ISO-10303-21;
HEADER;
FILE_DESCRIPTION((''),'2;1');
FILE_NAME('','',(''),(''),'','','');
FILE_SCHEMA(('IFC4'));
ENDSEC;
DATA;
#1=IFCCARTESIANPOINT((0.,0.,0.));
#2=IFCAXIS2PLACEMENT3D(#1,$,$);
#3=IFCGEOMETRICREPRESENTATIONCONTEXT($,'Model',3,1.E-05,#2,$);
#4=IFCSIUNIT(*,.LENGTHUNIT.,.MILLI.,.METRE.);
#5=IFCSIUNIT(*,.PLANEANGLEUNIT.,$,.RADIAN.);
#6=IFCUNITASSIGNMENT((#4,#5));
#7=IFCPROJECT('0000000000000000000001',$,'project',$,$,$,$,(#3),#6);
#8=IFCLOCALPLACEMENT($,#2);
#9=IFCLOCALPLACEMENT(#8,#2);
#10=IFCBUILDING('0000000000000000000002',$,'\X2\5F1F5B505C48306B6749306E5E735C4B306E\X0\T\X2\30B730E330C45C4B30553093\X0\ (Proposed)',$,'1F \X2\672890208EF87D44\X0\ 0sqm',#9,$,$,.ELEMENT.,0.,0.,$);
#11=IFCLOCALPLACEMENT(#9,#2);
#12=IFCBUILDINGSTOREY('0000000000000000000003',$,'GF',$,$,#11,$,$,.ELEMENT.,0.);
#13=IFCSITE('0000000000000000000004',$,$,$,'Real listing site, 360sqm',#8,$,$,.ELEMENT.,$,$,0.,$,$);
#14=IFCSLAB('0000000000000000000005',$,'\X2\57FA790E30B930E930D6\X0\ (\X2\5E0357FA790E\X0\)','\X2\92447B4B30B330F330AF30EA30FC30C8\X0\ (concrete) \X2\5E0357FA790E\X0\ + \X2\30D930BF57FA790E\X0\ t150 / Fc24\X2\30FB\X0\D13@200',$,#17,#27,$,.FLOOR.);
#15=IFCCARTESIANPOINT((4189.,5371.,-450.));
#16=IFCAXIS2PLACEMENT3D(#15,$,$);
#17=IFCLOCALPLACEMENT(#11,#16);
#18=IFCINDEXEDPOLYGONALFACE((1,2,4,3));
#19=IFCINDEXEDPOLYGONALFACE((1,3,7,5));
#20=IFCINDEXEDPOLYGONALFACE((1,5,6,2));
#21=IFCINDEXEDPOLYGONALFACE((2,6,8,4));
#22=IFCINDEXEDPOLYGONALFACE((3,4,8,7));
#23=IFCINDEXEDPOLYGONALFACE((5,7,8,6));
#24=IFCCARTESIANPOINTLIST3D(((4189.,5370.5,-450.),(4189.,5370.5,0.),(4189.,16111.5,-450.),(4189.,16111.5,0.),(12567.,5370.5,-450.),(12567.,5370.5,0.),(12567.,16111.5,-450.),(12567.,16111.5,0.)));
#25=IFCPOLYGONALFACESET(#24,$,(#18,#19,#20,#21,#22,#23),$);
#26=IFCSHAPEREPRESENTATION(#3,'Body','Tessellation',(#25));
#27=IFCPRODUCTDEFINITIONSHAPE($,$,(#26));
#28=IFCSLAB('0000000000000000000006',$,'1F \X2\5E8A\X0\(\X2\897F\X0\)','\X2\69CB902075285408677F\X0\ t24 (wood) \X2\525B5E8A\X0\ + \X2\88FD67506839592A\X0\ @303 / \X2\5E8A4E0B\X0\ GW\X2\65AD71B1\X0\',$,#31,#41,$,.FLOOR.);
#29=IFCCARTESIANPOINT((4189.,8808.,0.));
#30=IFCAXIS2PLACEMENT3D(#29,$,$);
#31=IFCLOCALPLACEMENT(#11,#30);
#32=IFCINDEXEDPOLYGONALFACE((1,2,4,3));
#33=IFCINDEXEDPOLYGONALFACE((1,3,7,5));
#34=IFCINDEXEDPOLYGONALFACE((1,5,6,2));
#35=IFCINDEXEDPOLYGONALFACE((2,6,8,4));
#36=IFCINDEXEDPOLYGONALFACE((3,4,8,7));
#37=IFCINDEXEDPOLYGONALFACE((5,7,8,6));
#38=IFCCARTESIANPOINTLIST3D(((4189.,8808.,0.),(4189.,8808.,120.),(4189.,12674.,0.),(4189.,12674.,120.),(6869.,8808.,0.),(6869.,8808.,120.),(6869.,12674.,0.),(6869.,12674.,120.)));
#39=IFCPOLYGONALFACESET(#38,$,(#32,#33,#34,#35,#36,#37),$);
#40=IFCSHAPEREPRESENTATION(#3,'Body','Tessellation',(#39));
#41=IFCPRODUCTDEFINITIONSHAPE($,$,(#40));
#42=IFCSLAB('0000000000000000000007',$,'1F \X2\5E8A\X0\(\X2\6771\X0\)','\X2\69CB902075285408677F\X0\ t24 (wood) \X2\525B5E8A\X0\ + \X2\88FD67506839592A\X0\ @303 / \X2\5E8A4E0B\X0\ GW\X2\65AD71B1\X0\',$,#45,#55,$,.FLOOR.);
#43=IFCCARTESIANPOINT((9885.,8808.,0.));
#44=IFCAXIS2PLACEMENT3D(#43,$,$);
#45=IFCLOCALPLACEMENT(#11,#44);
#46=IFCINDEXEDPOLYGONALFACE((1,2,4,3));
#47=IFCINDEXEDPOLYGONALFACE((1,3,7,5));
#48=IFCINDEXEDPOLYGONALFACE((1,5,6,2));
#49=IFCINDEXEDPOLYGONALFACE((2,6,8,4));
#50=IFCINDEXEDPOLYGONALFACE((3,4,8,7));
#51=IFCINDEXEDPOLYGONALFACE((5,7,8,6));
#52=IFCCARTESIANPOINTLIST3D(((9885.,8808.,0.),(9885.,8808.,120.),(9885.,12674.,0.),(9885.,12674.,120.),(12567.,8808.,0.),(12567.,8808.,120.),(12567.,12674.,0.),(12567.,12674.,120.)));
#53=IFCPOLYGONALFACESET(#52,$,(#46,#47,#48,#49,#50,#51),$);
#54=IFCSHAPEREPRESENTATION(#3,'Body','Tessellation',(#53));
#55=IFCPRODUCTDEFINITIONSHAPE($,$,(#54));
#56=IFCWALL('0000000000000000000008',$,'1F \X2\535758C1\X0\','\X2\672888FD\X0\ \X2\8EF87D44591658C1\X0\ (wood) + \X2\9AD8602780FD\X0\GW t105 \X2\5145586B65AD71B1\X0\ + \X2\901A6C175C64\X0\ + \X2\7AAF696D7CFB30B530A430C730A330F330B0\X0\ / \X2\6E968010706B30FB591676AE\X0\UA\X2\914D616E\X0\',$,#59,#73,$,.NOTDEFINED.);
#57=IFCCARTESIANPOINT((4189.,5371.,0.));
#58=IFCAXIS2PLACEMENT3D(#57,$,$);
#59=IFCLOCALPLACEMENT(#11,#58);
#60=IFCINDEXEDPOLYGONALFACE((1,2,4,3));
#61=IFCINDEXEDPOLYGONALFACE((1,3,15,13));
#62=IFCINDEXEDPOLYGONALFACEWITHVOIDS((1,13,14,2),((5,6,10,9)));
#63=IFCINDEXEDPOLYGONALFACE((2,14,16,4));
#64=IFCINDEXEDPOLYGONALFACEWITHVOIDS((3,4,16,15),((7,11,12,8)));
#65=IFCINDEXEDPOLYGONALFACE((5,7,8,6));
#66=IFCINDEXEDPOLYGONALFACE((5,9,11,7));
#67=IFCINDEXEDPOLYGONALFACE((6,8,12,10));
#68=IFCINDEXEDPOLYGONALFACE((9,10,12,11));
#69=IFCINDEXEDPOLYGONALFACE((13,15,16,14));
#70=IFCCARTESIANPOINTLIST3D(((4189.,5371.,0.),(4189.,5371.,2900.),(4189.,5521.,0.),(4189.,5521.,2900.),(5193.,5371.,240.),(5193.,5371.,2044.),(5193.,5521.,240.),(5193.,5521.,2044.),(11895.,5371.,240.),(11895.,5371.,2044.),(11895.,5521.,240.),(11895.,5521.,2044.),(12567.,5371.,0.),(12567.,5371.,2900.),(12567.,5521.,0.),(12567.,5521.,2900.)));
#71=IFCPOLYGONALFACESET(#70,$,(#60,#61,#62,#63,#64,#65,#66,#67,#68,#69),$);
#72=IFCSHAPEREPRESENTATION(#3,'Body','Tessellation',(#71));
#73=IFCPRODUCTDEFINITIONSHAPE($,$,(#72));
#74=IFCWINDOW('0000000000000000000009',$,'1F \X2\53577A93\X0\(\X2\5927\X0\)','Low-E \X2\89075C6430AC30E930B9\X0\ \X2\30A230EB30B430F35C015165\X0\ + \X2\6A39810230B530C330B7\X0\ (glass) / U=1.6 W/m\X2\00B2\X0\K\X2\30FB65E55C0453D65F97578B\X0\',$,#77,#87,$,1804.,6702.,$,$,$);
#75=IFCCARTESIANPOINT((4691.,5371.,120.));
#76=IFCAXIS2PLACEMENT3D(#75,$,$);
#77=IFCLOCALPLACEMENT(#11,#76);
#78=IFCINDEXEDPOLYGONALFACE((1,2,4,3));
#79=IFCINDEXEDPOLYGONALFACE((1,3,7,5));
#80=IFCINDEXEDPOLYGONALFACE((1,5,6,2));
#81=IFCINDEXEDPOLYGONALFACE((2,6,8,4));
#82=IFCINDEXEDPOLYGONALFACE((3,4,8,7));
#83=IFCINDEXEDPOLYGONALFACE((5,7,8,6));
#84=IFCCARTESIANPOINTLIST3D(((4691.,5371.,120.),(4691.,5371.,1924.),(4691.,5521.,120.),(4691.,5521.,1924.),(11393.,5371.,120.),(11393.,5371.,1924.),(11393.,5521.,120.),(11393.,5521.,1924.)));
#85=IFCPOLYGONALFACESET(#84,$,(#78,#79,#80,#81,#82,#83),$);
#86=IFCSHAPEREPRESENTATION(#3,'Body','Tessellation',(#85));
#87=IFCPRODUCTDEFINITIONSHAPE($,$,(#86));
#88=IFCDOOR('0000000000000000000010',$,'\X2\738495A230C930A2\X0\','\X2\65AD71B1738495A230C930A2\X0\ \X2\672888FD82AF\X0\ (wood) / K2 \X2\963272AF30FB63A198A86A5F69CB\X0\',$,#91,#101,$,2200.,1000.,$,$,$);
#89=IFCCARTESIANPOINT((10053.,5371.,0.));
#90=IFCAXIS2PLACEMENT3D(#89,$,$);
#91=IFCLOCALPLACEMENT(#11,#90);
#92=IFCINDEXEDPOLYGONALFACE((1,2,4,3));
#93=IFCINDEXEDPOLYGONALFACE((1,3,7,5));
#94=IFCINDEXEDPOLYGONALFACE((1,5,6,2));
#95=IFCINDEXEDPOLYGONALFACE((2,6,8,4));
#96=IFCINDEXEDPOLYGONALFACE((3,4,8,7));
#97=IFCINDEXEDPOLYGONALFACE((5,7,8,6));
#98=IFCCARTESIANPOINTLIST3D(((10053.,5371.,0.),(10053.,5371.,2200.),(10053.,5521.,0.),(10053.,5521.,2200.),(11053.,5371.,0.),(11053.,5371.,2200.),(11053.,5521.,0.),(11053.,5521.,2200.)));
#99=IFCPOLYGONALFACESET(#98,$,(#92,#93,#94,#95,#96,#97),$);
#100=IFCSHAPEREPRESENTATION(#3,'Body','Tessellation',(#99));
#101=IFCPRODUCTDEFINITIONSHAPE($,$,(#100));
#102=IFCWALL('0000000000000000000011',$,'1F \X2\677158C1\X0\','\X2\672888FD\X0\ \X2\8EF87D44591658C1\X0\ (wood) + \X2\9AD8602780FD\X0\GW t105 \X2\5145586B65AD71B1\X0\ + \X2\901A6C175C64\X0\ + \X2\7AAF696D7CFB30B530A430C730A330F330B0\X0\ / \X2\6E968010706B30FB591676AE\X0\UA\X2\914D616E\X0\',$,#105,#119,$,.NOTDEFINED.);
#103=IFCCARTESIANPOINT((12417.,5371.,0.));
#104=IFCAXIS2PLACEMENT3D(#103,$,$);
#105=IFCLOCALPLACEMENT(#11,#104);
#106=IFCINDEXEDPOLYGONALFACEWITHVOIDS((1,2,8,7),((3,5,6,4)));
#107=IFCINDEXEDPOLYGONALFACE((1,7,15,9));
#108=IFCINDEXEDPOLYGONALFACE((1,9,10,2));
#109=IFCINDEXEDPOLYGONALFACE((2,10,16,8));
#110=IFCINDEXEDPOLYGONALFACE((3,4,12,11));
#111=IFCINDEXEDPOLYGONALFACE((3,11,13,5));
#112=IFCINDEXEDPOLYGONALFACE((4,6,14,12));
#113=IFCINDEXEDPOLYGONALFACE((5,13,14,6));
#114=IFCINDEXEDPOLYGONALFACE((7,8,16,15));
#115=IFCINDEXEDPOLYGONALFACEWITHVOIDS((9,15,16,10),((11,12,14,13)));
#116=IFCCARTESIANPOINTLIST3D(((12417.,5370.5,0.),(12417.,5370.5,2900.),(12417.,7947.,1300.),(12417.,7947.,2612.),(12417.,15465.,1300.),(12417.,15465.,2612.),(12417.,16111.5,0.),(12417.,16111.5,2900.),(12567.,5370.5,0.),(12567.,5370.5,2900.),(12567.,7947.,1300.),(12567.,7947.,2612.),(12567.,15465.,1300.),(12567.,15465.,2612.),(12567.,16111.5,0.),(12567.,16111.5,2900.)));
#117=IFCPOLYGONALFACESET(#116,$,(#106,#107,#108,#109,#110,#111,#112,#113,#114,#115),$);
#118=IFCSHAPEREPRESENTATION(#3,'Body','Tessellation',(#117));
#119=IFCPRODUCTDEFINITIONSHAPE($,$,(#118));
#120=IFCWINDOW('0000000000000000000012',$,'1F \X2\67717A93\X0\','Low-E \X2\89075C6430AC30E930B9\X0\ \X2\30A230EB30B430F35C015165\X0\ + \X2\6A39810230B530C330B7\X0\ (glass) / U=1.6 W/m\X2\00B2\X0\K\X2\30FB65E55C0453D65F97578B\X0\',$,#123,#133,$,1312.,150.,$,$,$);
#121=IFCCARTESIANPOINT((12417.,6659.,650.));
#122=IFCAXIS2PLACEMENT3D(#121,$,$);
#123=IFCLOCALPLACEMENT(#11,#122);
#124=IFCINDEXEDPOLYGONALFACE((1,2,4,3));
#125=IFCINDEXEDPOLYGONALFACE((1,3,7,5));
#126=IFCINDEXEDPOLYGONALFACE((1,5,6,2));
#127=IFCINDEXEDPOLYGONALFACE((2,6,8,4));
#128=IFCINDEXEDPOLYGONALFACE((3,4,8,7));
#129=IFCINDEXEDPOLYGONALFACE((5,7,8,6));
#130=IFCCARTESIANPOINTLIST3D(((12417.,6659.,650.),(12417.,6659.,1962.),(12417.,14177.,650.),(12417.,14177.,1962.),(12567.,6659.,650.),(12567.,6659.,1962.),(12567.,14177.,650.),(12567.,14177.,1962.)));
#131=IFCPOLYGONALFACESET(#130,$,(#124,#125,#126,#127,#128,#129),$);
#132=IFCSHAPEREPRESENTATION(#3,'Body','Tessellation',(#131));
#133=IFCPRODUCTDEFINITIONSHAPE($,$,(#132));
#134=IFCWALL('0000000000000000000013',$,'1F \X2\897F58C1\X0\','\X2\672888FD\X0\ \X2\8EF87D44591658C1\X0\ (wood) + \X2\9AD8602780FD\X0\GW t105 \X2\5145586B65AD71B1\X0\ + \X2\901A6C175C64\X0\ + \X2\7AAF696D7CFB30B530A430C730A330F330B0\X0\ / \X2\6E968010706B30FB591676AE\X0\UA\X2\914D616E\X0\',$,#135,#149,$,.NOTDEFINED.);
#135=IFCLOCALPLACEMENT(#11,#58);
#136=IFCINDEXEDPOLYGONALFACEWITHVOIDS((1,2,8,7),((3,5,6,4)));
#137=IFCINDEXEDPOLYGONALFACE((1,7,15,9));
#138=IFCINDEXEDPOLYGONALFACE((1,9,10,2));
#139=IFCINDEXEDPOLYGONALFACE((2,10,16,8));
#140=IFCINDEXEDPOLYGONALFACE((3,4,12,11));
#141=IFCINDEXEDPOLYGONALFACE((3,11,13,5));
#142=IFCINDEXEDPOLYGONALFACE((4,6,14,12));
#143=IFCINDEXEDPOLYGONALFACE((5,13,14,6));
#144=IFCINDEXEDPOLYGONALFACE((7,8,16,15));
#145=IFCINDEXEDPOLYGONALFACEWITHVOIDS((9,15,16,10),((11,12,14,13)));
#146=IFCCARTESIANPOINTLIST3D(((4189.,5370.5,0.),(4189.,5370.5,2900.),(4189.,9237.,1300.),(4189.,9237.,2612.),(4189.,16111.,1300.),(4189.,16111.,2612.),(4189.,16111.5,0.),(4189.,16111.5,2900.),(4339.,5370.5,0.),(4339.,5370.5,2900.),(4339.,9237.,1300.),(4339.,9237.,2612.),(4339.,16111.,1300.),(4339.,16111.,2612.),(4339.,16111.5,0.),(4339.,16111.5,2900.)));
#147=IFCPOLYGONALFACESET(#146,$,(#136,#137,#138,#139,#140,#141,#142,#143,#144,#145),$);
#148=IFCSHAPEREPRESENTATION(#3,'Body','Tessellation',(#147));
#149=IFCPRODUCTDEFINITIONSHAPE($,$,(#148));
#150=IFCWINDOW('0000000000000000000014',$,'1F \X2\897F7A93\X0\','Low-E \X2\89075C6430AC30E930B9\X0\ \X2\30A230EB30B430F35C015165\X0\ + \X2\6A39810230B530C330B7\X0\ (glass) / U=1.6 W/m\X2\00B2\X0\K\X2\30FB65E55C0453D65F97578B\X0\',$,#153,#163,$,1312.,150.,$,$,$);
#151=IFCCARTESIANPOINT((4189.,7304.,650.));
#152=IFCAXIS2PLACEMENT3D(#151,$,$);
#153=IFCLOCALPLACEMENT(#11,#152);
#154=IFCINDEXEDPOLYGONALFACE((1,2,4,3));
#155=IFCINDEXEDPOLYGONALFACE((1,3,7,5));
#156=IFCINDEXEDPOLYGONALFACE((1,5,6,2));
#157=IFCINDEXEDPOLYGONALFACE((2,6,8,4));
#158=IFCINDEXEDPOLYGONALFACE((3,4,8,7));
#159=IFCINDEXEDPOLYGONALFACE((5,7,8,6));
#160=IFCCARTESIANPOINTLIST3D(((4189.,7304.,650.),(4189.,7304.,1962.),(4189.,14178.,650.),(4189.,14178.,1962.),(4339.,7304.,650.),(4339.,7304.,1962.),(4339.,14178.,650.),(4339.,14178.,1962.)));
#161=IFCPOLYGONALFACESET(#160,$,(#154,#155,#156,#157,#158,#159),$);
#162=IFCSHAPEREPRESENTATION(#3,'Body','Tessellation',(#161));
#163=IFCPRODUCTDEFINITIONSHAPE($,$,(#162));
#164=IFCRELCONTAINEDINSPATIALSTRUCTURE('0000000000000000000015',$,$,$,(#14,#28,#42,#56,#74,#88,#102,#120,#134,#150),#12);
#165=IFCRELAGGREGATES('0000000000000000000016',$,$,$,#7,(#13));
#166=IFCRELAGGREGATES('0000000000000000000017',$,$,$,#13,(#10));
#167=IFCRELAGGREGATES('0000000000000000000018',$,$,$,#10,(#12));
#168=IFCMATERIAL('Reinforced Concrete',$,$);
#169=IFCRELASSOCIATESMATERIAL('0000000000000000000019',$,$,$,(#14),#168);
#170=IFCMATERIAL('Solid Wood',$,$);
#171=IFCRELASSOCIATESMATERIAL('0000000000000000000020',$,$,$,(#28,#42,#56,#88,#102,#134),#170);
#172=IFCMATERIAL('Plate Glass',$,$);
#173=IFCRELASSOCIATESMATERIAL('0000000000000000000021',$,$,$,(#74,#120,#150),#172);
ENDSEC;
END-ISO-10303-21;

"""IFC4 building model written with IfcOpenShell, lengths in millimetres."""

from ifc_helpers import new_model, si_unit, frame, frame_2d, origin, place, context, project, spatial, rectangle, extrude, material, element, fill, save


model = new_model("IFC4")

# Units and contexts
model_context = context("Model", 3, precision=1e-05, world=origin())
ifc_project = project(units=[si_unit("LENGTHUNIT", "METRE", prefix="MILLI"), si_unit("PLANEANGLEUNIT", "RADIAN")], contexts=[model_context])

# Site, building, storey
site_placement = place(None, origin())
site = spatial("IfcSite", under=ifc_project, at=site_placement, ObjectType="Real listing site, 360sqm", CompositionType="ELEMENT", RefElevation=0.0)
building_placement = place(site_placement, origin())
building = spatial("IfcBuilding", under=site, at=building_placement, Name="弟子屈に杉の平屋のTシャツ屋さん (Proposed)", ObjectType="1F 木造軸組 0sqm", CompositionType="ELEMENT", ElevationOfRefHeight=0.0, ElevationOfTerrain=0.0)
storey_placement = place(building_placement, origin())
storey = spatial("IfcBuildingStorey", under=building, at=storey_placement, Name="GF", CompositionType="ELEMENT", Elevation=0.0)

# Slabs
ifc_material_1 = material(Name="Reinforced Concrete")
slab_1_placement = place(storey_placement, frame((4189.0, 5371.0, -450.0)))
element("IfcSlab", 1, at=slab_1_placement, inside=storey, material=ifc_material_1, Name="基礎スラブ (布基礎)", Description="鉄筋コンクリート (concrete) 布基礎 + ベタ基礎 t150 / Fc24・D13@200", PredefinedType="FLOOR", context=model_context, shape_type="SweptSolid", body=[
    extrude(rectangle(XDim=8378.0, YDim=10741.0, at=frame_2d((4189.0, 5370.0))), frame((4189.0, 5371.0, -450.0)), (0.0, 0.0, 1.0), 450.0),
])
ifc_material_2 = material(Name="Solid Wood")
slab_2_placement = place(storey_placement, frame((4189.0, 8808.0, 0.0)))
element("IfcSlab", 2, at=slab_2_placement, inside=storey, material=ifc_material_2, Name="1F 床(西)", Description="構造用合板 t24 (wood) 剛床 + 製材根太 @303 / 床下 GW断熱", PredefinedType="FLOOR", context=model_context, shape_type="SweptSolid", body=[
    extrude(rectangle(XDim=2680.0, YDim=3866.0, at=frame_2d((1340.0, 1933.0))), frame((4189.0, 8808.0, 0.0)), (0.0, 0.0, 1.0), 120.0),
])
slab_3_placement = place(storey_placement, frame((9885.0, 8808.0, 0.0)))
element("IfcSlab", 3, at=slab_3_placement, inside=storey, material=ifc_material_2, Name="1F 床(東)", Description="構造用合板 t24 (wood) 剛床 + 製材根太 @303 / 床下 GW断熱", PredefinedType="FLOOR", context=model_context, shape_type="SweptSolid", body=[
    extrude(rectangle(XDim=2682.0, YDim=3866.0, at=frame_2d((1341.0, 1933.0))), frame((9885.0, 8808.0, 0.0)), (0.0, 0.0, 1.0), 120.0),
])

# Wall, openings, window, door
wall_1_placement = place(storey_placement, frame((4189.0, 5371.0, 0.0)))
wall_1 = element("IfcWall", 4, at=wall_1_placement, inside=storey, material=ifc_material_2, Name="1F 南壁", Description="木製 軸組外壁 (wood) + 高性能GW t105 充填断熱 + 通気層 + 窯業系サイディング / 準耐火・外皮UA配慮", PredefinedType="NOTDEFINED", context=model_context, shape_type="SweptSolid", body=[
    extrude(rectangle(XDim=8378.0, YDim=150.0, at=frame_2d((4189.0, 75.0))), frame((4189.0, 5371.0, 0.0)), (0.0, 0.0, 1.0), 2900.0),
])
opening_1_placement = place(storey_placement, frame((4691.0, 5371.0, 120.0)))
opening_1 = element("IfcOpeningElement", 5, at=opening_1_placement, cuts=wall_1, PredefinedType="NOTDEFINED", context=model_context, shape_type="SweptSolid", body=[
    extrude(rectangle(XDim=6702.0, YDim=150.0, at=frame_2d((3351.0, 75.0))), frame((4691.0, 5371.0, 120.0)), (0.0, 0.0, 1.0), 1804.0),
])
opening_2_placement = place(storey_placement, frame((10053.0, 5371.0, 0.0)))
opening_2 = element("IfcOpeningElement", 6, at=opening_2_placement, cuts=wall_1, PredefinedType="NOTDEFINED", context=model_context, shape_type="SweptSolid", body=[
    extrude(rectangle(XDim=1000.0, YDim=150.0, at=frame_2d((500.0, 75.0))), frame((10053.0, 5371.0, 0.0)), (0.0, 0.0, 1.0), 2200.0),
])
ifc_material_3 = material(Name="Plate Glass")
window_1_placement = place(storey_placement, frame((4691.0, 5371.0, 120.0)))
window_1 = element("IfcWindow", 7, at=window_1_placement, inside=storey, material=ifc_material_3, Name="1F 南窓(大)", Description="Low-E 複層ガラス アルゴン封入 + 樹脂サッシ (glass) / U=1.6 W/m²K・日射取得型", OverallHeight=1804.0, OverallWidth=6702.0, context=model_context, shape_type="SweptSolid", body=[
    extrude(rectangle(XDim=6702.0, YDim=150.0, at=frame_2d((3351.0, 75.0))), frame((4691.0, 5371.0, 120.0)), (0.0, 0.0, 1.0), 1804.0),
])
fill(opening_1, window_1)
door_placement = place(storey_placement, frame((10053.0, 5371.0, 0.0)))
door = element("IfcDoor", 8, at=door_placement, inside=storey, material=ifc_material_2, Name="玄関ドア", Description="断熱玄関ドア 木製芯 (wood) / K2 防犯・採風機構", OverallHeight=2200.0, OverallWidth=1000.0, context=model_context, shape_type="SweptSolid", body=[
    extrude(rectangle(XDim=1000.0, YDim=150.0, at=frame_2d((500.0, 75.0))), frame((10053.0, 5371.0, 0.0)), (0.0, 0.0, 1.0), 2200.0),
])
fill(opening_2, door)

# Walls, openings, windows
wall_2_placement = place(storey_placement, frame((12417.0, 5371.0, 0.0)))
wall_2 = element("IfcWall", 9, at=wall_2_placement, inside=storey, material=ifc_material_2, Name="1F 東壁", Description="木製 軸組外壁 (wood) + 高性能GW t105 充填断熱 + 通気層 + 窯業系サイディング / 準耐火・外皮UA配慮", PredefinedType="NOTDEFINED", context=model_context, shape_type="SweptSolid", body=[
    extrude(rectangle(XDim=150.0, YDim=10741.0, at=frame_2d((75.0, 5370.0))), frame((12417.0, 5371.0, 0.0)), (0.0, 0.0, 1.0), 2900.0),
])
opening_3_placement = place(storey_placement, frame((12417.0, 6659.0, 650.0)))
opening_3 = element("IfcOpeningElement", 10, at=opening_3_placement, cuts=wall_2, PredefinedType="NOTDEFINED", context=model_context, shape_type="SweptSolid", body=[
    extrude(rectangle(XDim=150.0, YDim=7518.0, at=frame_2d((75.0, 3759.0))), frame((12417.0, 6659.0, 650.0)), (0.0, 0.0, 1.0), 1312.0),
])
window_2_placement = place(storey_placement, frame((12417.0, 6659.0, 650.0)))
window_2 = element("IfcWindow", 11, at=window_2_placement, inside=storey, material=ifc_material_3, Name="1F 東窓", Description="Low-E 複層ガラス アルゴン封入 + 樹脂サッシ (glass) / U=1.6 W/m²K・日射取得型", OverallHeight=1312.0, OverallWidth=150.0, context=model_context, shape_type="SweptSolid", body=[
    extrude(rectangle(XDim=150.0, YDim=7518.0, at=frame_2d((75.0, 3759.0))), frame((12417.0, 6659.0, 650.0)), (0.0, 0.0, 1.0), 1312.0),
])
fill(opening_3, window_2)
wall_3_placement = place(storey_placement, frame((4189.0, 5371.0, 0.0)))
wall_3 = element("IfcWall", 12, at=wall_3_placement, inside=storey, material=ifc_material_2, Name="1F 西壁", Description="木製 軸組外壁 (wood) + 高性能GW t105 充填断熱 + 通気層 + 窯業系サイディング / 準耐火・外皮UA配慮", PredefinedType="NOTDEFINED", context=model_context, shape_type="SweptSolid", body=[
    extrude(rectangle(XDim=150.0, YDim=10741.0, at=frame_2d((75.0, 5370.0))), frame((4189.0, 5371.0, 0.0)), (0.0, 0.0, 1.0), 2900.0),
])
opening_4_placement = place(storey_placement, frame((4189.0, 7304.0, 650.0)))
opening_4 = element("IfcOpeningElement", 13, at=opening_4_placement, cuts=wall_3, PredefinedType="NOTDEFINED", context=model_context, shape_type="SweptSolid", body=[
    extrude(rectangle(XDim=150.0, YDim=6874.0, at=frame_2d((75.0, 3437.0))), frame((4189.0, 7304.0, 650.0)), (0.0, 0.0, 1.0), 1312.0),
])
window_3_placement = place(storey_placement, frame((4189.0, 7304.0, 650.0)))
window_3 = element("IfcWindow", 14, at=window_3_placement, inside=storey, material=ifc_material_3, Name="1F 西窓", Description="Low-E 複層ガラス アルゴン封入 + 樹脂サッシ (glass) / U=1.6 W/m²K・日射取得型", OverallHeight=1312.0, OverallWidth=150.0, context=model_context, shape_type="SweptSolid", body=[
    extrude(rectangle(XDim=150.0, YDim=6874.0, at=frame_2d((75.0, 3437.0))), frame((4189.0, 7304.0, 650.0)), (0.0, 0.0, 1.0), 1312.0),
])
fill(opening_4, window_3)

save(model, "model.ifc")
